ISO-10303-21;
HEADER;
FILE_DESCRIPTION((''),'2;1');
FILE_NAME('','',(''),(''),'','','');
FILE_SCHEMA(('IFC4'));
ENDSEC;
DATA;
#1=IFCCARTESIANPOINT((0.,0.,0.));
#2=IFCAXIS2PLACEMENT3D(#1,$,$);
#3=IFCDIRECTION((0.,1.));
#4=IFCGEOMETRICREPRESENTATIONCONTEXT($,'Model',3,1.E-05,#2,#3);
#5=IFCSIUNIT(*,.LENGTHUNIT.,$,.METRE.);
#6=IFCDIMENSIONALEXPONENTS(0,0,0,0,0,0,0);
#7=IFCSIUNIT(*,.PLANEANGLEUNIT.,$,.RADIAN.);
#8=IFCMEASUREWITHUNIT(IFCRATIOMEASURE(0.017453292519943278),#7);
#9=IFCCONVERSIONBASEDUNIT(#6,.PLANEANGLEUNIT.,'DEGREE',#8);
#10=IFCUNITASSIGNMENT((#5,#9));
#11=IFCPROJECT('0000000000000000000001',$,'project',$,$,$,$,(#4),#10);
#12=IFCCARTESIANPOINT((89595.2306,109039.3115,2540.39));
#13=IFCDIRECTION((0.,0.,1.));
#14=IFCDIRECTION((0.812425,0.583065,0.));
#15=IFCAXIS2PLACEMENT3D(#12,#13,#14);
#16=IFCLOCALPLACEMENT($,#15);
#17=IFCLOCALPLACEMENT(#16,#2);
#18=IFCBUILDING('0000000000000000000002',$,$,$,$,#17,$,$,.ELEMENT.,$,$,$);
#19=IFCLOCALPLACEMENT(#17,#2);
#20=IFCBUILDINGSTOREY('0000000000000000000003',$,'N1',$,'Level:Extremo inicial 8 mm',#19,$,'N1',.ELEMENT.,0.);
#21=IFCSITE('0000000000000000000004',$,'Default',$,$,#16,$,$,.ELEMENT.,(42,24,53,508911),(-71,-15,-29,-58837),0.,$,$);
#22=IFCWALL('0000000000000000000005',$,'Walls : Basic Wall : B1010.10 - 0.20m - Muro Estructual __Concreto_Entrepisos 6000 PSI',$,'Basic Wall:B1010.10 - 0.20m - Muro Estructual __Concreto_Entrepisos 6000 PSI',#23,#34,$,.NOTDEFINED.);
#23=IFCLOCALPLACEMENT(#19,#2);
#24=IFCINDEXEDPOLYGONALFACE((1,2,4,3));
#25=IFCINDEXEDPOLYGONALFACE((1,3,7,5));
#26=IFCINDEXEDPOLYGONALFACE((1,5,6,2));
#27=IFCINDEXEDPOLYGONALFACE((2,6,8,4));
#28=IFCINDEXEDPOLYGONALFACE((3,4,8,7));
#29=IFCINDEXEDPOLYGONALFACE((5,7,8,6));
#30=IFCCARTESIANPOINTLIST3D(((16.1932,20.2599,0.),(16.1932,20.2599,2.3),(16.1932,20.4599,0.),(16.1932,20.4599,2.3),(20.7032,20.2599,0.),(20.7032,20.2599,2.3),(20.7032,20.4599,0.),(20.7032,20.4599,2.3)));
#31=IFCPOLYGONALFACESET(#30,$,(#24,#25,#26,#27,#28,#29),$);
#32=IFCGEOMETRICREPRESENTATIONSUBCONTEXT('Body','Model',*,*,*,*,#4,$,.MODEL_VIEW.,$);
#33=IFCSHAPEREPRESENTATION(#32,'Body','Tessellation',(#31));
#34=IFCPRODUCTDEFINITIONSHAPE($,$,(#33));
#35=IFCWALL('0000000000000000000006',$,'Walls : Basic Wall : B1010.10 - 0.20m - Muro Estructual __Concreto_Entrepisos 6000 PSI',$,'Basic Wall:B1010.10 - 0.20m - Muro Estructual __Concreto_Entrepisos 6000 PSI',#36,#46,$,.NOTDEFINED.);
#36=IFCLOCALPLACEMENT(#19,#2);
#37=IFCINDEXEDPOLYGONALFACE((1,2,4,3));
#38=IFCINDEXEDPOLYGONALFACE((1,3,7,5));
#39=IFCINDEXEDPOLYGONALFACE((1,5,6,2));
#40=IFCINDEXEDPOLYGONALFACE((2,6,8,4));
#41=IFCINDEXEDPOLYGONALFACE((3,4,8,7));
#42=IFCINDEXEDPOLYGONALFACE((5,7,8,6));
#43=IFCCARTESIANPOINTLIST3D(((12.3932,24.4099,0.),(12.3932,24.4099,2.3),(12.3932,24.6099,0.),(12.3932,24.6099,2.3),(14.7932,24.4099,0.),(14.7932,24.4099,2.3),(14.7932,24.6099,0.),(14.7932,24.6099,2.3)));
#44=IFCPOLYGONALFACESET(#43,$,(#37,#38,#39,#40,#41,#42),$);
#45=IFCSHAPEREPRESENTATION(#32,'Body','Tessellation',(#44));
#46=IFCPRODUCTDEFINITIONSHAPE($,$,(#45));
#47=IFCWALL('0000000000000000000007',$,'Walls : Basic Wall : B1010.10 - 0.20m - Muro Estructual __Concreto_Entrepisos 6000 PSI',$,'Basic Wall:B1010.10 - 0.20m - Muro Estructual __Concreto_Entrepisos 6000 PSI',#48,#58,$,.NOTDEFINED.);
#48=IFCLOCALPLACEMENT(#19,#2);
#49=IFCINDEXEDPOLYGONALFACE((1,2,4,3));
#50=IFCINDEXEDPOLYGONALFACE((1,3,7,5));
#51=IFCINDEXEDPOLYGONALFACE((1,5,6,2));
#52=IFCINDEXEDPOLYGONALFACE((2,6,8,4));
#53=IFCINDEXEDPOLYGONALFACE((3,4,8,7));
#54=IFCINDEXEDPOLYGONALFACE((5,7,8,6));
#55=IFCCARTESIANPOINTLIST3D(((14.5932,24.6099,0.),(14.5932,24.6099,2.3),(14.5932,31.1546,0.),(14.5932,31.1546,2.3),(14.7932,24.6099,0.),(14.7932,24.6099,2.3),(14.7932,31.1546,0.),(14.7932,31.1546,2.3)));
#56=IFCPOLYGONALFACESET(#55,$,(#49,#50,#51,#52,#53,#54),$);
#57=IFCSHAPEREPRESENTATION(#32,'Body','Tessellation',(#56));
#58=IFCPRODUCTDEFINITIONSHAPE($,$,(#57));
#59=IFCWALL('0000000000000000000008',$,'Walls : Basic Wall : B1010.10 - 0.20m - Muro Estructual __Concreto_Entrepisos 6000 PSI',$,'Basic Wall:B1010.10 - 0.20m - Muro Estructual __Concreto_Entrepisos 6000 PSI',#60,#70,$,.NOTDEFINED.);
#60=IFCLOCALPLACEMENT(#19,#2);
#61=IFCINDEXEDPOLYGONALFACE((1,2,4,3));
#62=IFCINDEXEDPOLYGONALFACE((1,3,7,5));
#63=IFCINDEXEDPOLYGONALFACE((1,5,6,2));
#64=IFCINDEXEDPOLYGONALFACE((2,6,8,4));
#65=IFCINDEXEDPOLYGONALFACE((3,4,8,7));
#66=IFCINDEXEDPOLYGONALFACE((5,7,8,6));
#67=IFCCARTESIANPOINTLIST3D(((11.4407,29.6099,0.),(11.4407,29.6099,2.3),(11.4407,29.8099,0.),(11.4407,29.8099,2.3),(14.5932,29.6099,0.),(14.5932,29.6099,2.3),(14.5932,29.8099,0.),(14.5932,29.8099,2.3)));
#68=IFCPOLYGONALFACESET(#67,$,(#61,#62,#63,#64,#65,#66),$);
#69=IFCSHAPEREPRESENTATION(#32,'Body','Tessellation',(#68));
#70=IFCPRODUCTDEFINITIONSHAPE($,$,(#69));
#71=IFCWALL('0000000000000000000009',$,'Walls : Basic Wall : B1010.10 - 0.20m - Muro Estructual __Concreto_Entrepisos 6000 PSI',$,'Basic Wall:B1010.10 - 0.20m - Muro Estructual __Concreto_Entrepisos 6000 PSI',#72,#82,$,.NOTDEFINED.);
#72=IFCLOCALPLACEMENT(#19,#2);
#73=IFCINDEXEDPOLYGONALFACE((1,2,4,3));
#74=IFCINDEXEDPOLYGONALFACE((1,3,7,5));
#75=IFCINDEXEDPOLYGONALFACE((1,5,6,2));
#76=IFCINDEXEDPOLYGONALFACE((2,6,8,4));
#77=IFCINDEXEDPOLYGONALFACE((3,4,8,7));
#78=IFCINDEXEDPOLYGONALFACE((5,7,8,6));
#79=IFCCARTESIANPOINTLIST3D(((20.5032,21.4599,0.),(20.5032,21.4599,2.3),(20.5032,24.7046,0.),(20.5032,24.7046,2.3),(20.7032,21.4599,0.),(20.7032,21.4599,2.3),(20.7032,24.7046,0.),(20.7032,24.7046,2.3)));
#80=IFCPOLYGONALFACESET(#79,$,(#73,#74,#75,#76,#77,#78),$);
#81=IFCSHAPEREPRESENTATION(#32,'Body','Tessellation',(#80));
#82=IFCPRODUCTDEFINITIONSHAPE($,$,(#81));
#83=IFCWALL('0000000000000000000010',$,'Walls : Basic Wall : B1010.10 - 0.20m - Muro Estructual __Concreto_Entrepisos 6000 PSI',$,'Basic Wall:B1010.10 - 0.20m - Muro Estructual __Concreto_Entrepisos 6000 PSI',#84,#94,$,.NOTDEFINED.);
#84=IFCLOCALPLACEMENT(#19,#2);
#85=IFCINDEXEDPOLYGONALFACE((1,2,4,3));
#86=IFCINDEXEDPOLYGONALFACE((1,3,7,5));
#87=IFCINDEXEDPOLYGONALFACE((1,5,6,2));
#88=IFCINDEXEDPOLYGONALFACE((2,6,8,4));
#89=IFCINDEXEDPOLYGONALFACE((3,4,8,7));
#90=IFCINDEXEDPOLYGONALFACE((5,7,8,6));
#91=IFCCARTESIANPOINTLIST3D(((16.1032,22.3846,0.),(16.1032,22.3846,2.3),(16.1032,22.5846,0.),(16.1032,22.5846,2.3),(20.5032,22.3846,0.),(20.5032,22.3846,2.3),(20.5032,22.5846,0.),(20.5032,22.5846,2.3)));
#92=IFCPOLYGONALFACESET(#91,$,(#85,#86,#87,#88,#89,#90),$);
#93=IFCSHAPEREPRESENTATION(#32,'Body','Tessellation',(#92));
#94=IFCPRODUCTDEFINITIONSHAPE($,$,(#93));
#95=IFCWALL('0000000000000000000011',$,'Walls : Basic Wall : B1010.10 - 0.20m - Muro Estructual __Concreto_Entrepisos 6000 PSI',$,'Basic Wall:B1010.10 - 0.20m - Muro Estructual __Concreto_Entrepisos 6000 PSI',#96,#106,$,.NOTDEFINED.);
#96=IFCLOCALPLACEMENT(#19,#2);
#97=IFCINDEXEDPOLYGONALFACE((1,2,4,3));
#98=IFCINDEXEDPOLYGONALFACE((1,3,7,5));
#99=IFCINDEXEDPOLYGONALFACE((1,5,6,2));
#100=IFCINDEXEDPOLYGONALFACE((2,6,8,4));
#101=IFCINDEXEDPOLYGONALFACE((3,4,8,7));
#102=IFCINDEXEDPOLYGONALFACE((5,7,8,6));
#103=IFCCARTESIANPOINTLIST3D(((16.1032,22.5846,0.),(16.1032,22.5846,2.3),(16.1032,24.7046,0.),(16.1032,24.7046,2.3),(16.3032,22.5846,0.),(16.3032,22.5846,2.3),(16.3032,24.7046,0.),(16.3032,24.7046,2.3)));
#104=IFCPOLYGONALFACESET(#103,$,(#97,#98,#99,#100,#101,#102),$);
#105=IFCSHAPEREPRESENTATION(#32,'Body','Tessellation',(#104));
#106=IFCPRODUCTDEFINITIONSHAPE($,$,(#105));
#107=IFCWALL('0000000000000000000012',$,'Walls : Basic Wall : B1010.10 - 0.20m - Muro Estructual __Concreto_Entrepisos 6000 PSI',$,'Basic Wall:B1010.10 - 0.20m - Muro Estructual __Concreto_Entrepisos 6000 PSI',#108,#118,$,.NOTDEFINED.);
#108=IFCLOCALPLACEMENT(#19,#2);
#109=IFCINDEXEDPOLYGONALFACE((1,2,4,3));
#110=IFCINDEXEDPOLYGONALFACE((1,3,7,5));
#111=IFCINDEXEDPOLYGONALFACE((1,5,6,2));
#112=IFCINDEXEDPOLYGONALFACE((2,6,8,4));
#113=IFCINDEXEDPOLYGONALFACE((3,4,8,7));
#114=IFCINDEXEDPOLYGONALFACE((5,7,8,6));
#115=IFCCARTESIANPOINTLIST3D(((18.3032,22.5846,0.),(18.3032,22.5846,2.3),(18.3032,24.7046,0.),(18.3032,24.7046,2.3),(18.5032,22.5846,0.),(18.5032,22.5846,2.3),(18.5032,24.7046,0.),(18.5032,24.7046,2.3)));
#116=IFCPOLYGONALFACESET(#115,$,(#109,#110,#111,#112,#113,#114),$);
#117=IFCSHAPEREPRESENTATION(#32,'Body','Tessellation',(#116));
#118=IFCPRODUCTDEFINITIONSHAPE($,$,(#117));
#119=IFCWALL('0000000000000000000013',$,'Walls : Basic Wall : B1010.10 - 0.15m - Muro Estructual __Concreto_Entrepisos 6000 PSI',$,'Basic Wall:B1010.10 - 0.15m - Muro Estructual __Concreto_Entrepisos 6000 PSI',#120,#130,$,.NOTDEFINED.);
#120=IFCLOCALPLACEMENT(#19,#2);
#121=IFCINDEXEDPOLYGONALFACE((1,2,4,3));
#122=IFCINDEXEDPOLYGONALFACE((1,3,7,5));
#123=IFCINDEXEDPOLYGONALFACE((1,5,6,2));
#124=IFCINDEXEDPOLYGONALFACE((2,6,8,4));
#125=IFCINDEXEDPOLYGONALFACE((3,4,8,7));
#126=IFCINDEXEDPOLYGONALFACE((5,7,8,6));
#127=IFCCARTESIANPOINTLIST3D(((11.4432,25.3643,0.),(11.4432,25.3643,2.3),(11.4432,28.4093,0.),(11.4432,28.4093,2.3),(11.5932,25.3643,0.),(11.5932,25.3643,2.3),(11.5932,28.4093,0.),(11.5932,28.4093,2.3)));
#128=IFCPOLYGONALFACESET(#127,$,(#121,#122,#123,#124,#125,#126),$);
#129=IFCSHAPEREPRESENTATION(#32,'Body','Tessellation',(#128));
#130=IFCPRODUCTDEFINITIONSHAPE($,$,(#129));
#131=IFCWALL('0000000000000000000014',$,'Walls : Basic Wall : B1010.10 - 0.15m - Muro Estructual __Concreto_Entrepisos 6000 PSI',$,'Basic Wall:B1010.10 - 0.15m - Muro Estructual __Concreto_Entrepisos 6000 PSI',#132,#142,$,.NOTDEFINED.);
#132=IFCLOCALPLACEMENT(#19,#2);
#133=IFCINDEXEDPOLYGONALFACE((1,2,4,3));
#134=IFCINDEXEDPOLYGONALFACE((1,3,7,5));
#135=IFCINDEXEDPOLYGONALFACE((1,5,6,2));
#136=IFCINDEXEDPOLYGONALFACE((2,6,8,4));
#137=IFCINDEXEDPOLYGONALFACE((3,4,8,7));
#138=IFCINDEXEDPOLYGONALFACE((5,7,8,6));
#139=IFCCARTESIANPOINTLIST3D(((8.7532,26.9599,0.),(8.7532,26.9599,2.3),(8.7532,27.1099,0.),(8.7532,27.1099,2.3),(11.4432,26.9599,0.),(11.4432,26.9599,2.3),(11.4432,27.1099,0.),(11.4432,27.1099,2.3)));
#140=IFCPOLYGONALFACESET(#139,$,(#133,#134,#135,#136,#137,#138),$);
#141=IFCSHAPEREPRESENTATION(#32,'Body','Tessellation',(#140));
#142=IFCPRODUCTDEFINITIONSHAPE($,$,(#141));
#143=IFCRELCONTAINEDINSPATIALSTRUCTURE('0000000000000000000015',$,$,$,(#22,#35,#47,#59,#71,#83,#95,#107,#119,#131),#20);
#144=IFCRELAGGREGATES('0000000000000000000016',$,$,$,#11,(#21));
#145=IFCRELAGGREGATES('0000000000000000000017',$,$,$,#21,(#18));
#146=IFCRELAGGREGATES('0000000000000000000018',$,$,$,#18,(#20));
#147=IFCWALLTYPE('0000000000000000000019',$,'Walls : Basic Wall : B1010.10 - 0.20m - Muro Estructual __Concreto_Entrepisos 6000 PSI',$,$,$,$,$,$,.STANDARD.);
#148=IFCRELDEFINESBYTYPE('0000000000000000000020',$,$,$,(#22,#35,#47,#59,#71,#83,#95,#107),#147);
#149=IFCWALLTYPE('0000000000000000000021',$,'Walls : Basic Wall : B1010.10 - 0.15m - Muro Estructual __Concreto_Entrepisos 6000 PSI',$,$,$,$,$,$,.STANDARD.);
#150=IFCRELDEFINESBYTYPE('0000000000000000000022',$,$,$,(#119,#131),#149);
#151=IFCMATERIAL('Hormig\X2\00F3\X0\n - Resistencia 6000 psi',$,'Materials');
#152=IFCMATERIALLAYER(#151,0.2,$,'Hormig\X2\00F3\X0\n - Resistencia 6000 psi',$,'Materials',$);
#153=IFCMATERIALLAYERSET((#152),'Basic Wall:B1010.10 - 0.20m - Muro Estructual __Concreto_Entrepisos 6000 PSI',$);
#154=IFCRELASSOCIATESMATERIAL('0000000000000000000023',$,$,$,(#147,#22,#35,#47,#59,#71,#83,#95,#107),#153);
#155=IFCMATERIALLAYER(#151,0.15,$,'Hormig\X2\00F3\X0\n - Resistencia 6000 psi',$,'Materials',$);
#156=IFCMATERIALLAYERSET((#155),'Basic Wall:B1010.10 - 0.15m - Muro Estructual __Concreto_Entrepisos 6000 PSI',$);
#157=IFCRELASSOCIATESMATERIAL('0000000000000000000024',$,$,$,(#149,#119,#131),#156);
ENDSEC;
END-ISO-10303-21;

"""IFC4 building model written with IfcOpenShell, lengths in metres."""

from ifc_helpers import new_model, entity, si_unit, converted_unit, direction, frame, frame_2d, origin, place, context, subcontext, project, spatial, rectangle, extrude, material, layer, layer_set, layer_usage, type_object, element, save


model = new_model("IFC4")

# Units and contexts
model_context = context("Model", 3, precision=1e-05, world=origin(), true_north=direction((0.0, 1.0)))
body_context = subcontext(model_context, "Body", "Model", "MODEL_VIEW")
ifc_project = project(units=[si_unit("LENGTHUNIT", "METRE"), converted_unit("PLANEANGLEUNIT", "DEGREE", entity("IfcRatioMeasure", 0.017453292519943278), si_unit("PLANEANGLEUNIT", "RADIAN"), dimensions=[0, 0, 0, 0, 0, 0, 0])], contexts=[model_context])

# Site, building, storey
site_placement = place(None, frame((89595.2306, 109039.3115, 2540.39), z_axis=(0.0, 0.0, 1.0), x_axis=(0.812425, 0.583065, 0.0)))
site = spatial("IfcSite", under=ifc_project, at=site_placement, Name="Default", CompositionType="ELEMENT", RefLatitude=(42, 24, 53, 508911), RefLongitude=(-71, -15, -29, -58837), RefElevation=0.0)
building_placement = place(site_placement, origin())
building = spatial("IfcBuilding", under=site, at=building_placement, CompositionType="ELEMENT")
storey_placement = place(building_placement, origin())
storey = spatial("IfcBuildingStorey", under=building, at=storey_placement, Name="N1", ObjectType="Level:Extremo inicial 8 mm", LongName="N1", CompositionType="ELEMENT", Elevation=0.0)

# Walls
ifc_material_1 = material(Name="Hormigón - Resistencia 6000 psi", Category="Materials")
ifc_layer_1 = layer(ifc_material_1, 0.2, Name="Hormigón - Resistencia 6000 psi", Category="Materials")
ifc_layer_set_1 = layer_set([ifc_layer_1], Name="Basic Wall:B1010.10 - 0.20m - Muro Estructual __Concreto_Entrepisos 6000 PSI")
ifc_layer_usage_1 = layer_usage(ifc_layer_set_1, "AXIS2", "NEGATIVE", 0.1)
wall_type_1 = type_object("IfcWallType", Name="Walls : Basic Wall : B1010.10 - 0.20m - Muro Estructual __Concreto_Entrepisos 6000 PSI", PredefinedType="STANDARD", material=ifc_layer_set_1)
wall_1_placement = place(storey_placement, frame((16.1932, 20.3599, 0.0)))
element("IfcWall", 1, at=wall_1_placement, inside=storey, type_object=wall_type_1, material=ifc_layer_usage_1, Name="Walls : Basic Wall : B1010.10 - 0.20m - Muro Estructual __Concreto_Entrepisos 6000 PSI", ObjectType="Basic Wall:B1010.10 - 0.20m - Muro Estructual __Concreto_Entrepisos 6000 PSI", PredefinedType="NOTDEFINED", context=body_context, shape_type="SweptSolid", body=[
    extrude(rectangle(XDim=4.51, YDim=0.2, at=frame_2d((2.255, 0.0), x_axis=(-1.0, 0.0))), origin(), (0.0, 0.0, 1.0), 2.3),
])
ifc_layer_usage_2 = layer_usage(ifc_layer_set_1, "AXIS2", "NEGATIVE", 0.1)
wall_2_placement = place(storey_placement, frame((12.3932, 24.5099, 0.0)))
element("IfcWall", 2, at=wall_2_placement, inside=storey, type_object=wall_type_1, material=ifc_layer_usage_2, Name="Walls : Basic Wall : B1010.10 - 0.20m - Muro Estructual __Concreto_Entrepisos 6000 PSI", ObjectType="Basic Wall:B1010.10 - 0.20m - Muro Estructual __Concreto_Entrepisos 6000 PSI", PredefinedType="NOTDEFINED", context=body_context, shape_type="SweptSolid", body=[
    extrude(rectangle(XDim=2.4, YDim=0.2, at=frame_2d((1.2, 0.0), x_axis=(-1.0, 0.0))), origin(), (0.0, 0.0, 1.0), 2.3),
])
ifc_layer_usage_3 = layer_usage(ifc_layer_set_1, "AXIS2", "NEGATIVE", 0.1)
wall_3_placement = place(storey_placement, frame((14.6932, 24.6099, 0.0), z_axis=(0.0, 0.0, 1.0), x_axis=(0.0, 1.0, 0.0)))
element("IfcWall", 3, at=wall_3_placement, inside=storey, type_object=wall_type_1, material=ifc_layer_usage_3, Name="Walls : Basic Wall : B1010.10 - 0.20m - Muro Estructual __Concreto_Entrepisos 6000 PSI", ObjectType="Basic Wall:B1010.10 - 0.20m - Muro Estructual __Concreto_Entrepisos 6000 PSI", PredefinedType="NOTDEFINED", context=body_context, shape_type="SweptSolid", body=[
    extrude(rectangle(XDim=6.5447, YDim=0.2, at=frame_2d((3.2724, 0.0), x_axis=(-1.0, 0.0))), origin(), (0.0, 0.0, 1.0), 2.3),
])
ifc_layer_usage_4 = layer_usage(ifc_layer_set_1, "AXIS2", "NEGATIVE", 0.1)
wall_4_placement = place(storey_placement, frame((11.4407, 29.7099, 0.0)))
element("IfcWall", 4, at=wall_4_placement, inside=storey, type_object=wall_type_1, material=ifc_layer_usage_4, Name="Walls : Basic Wall : B1010.10 - 0.20m - Muro Estructual __Concreto_Entrepisos 6000 PSI", ObjectType="Basic Wall:B1010.10 - 0.20m - Muro Estructual __Concreto_Entrepisos 6000 PSI", PredefinedType="NOTDEFINED", context=body_context, shape_type="SweptSolid", body=[
    extrude(rectangle(XDim=3.1525, YDim=0.2, at=frame_2d((1.5763, 0.0), x_axis=(-1.0, 0.0))), origin(), (0.0, 0.0, 1.0), 2.3),
])
ifc_layer_usage_5 = layer_usage(ifc_layer_set_1, "AXIS2", "NEGATIVE", 0.1)
wall_5_placement = place(storey_placement, frame((20.6032, 21.4599, 0.0), z_axis=(0.0, 0.0, 1.0), x_axis=(0.0, 1.0, 0.0)))
element("IfcWall", 5, at=wall_5_placement, inside=storey, type_object=wall_type_1, material=ifc_layer_usage_5, Name="Walls : Basic Wall : B1010.10 - 0.20m - Muro Estructual __Concreto_Entrepisos 6000 PSI", ObjectType="Basic Wall:B1010.10 - 0.20m - Muro Estructual __Concreto_Entrepisos 6000 PSI", PredefinedType="NOTDEFINED", context=body_context, shape_type="SweptSolid", body=[
    extrude(rectangle(XDim=3.2447, YDim=0.2, at=frame_2d((1.6224, 0.0), x_axis=(-1.0, 0.0))), origin(), (0.0, 0.0, 1.0), 2.3),
])
ifc_layer_usage_6 = layer_usage(ifc_layer_set_1, "AXIS2", "NEGATIVE", 0.1)
wall_6_placement = place(storey_placement, frame((20.5032, 22.4846, 0.0), z_axis=(0.0, 0.0, 1.0), x_axis=(-1.0, 0.0, 0.0)))
element("IfcWall", 6, at=wall_6_placement, inside=storey, type_object=wall_type_1, material=ifc_layer_usage_6, Name="Walls : Basic Wall : B1010.10 - 0.20m - Muro Estructual __Concreto_Entrepisos 6000 PSI", ObjectType="Basic Wall:B1010.10 - 0.20m - Muro Estructual __Concreto_Entrepisos 6000 PSI", PredefinedType="NOTDEFINED", context=body_context, shape_type="SweptSolid", body=[
    extrude(rectangle(XDim=4.4, YDim=0.2, at=frame_2d((2.2, 0.0), x_axis=(-1.0, 0.0))), origin(), (0.0, 0.0, 1.0), 2.3),
])
ifc_layer_usage_7 = layer_usage(ifc_layer_set_1, "AXIS2", "NEGATIVE", 0.1)
wall_7_placement = place(storey_placement, frame((16.2032, 22.5846, 0.0), z_axis=(0.0, 0.0, 1.0), x_axis=(0.0, 1.0, 0.0)))
element("IfcWall", 7, at=wall_7_placement, inside=storey, type_object=wall_type_1, material=ifc_layer_usage_7, Name="Walls : Basic Wall : B1010.10 - 0.20m - Muro Estructual __Concreto_Entrepisos 6000 PSI", ObjectType="Basic Wall:B1010.10 - 0.20m - Muro Estructual __Concreto_Entrepisos 6000 PSI", PredefinedType="NOTDEFINED", context=body_context, shape_type="SweptSolid", body=[
    extrude(rectangle(XDim=2.12, YDim=0.2, at=frame_2d((1.06, 0.0), x_axis=(-1.0, 0.0))), origin(), (0.0, 0.0, 1.0), 2.3),
])
ifc_layer_usage_8 = layer_usage(ifc_layer_set_1, "AXIS2", "NEGATIVE", 0.1)
wall_8_placement = place(storey_placement, frame((18.4032, 24.7046, 0.0), z_axis=(0.0, 0.0, 1.0), x_axis=(0.0, -1.0, 0.0)))
element("IfcWall", 8, at=wall_8_placement, inside=storey, type_object=wall_type_1, material=ifc_layer_usage_8, Name="Walls : Basic Wall : B1010.10 - 0.20m - Muro Estructual __Concreto_Entrepisos 6000 PSI", ObjectType="Basic Wall:B1010.10 - 0.20m - Muro Estructual __Concreto_Entrepisos 6000 PSI", PredefinedType="NOTDEFINED", context=body_context, shape_type="SweptSolid", body=[
    extrude(rectangle(XDim=2.12, YDim=0.2, at=frame_2d((1.06, 0.0), x_axis=(-1.0, 0.0))), origin(), (0.0, 0.0, 1.0), 2.3),
])
ifc_layer_2 = layer(ifc_material_1, 0.15, Name="Hormigón - Resistencia 6000 psi", Category="Materials")
ifc_layer_set_2 = layer_set([ifc_layer_2], Name="Basic Wall:B1010.10 - 0.15m - Muro Estructual __Concreto_Entrepisos 6000 PSI")
ifc_layer_usage_9 = layer_usage(ifc_layer_set_2, "AXIS2", "NEGATIVE", 0.075)
wall_type_2 = type_object("IfcWallType", Name="Walls : Basic Wall : B1010.10 - 0.15m - Muro Estructual __Concreto_Entrepisos 6000 PSI", PredefinedType="STANDARD", material=ifc_layer_set_2)
wall_9_placement = place(storey_placement, frame((11.5182, 25.3643, 0.0), z_axis=(0.0, 0.0, 1.0), x_axis=(0.0, 1.0, 0.0)))
element("IfcWall", 9, at=wall_9_placement, inside=storey, type_object=wall_type_2, material=ifc_layer_usage_9, Name="Walls : Basic Wall : B1010.10 - 0.15m - Muro Estructual __Concreto_Entrepisos 6000 PSI", ObjectType="Basic Wall:B1010.10 - 0.15m - Muro Estructual __Concreto_Entrepisos 6000 PSI", PredefinedType="NOTDEFINED", context=body_context, shape_type="SweptSolid", body=[
    extrude(rectangle(XDim=3.045, YDim=0.15, at=frame_2d((1.5225, 0.0), x_axis=(-1.0, 0.0))), origin(), (0.0, 0.0, 1.0), 2.3),
])
ifc_layer_usage_10 = layer_usage(ifc_layer_set_2, "AXIS2", "NEGATIVE", 0.075)
wall_10_placement = place(storey_placement, frame((8.7532, 27.0349, 0.0)))
element("IfcWall", 10, at=wall_10_placement, inside=storey, type_object=wall_type_2, material=ifc_layer_usage_10, Name="Walls : Basic Wall : B1010.10 - 0.15m - Muro Estructual __Concreto_Entrepisos 6000 PSI", ObjectType="Basic Wall:B1010.10 - 0.15m - Muro Estructual __Concreto_Entrepisos 6000 PSI", PredefinedType="NOTDEFINED", context=body_context, shape_type="SweptSolid", body=[
    extrude(rectangle(XDim=2.69, YDim=0.15, at=frame_2d((1.345, 0.0), x_axis=(-1.0, 0.0))), origin(), (0.0, 0.0, 1.0), 2.3),
])

save(model, "model.ifc")
